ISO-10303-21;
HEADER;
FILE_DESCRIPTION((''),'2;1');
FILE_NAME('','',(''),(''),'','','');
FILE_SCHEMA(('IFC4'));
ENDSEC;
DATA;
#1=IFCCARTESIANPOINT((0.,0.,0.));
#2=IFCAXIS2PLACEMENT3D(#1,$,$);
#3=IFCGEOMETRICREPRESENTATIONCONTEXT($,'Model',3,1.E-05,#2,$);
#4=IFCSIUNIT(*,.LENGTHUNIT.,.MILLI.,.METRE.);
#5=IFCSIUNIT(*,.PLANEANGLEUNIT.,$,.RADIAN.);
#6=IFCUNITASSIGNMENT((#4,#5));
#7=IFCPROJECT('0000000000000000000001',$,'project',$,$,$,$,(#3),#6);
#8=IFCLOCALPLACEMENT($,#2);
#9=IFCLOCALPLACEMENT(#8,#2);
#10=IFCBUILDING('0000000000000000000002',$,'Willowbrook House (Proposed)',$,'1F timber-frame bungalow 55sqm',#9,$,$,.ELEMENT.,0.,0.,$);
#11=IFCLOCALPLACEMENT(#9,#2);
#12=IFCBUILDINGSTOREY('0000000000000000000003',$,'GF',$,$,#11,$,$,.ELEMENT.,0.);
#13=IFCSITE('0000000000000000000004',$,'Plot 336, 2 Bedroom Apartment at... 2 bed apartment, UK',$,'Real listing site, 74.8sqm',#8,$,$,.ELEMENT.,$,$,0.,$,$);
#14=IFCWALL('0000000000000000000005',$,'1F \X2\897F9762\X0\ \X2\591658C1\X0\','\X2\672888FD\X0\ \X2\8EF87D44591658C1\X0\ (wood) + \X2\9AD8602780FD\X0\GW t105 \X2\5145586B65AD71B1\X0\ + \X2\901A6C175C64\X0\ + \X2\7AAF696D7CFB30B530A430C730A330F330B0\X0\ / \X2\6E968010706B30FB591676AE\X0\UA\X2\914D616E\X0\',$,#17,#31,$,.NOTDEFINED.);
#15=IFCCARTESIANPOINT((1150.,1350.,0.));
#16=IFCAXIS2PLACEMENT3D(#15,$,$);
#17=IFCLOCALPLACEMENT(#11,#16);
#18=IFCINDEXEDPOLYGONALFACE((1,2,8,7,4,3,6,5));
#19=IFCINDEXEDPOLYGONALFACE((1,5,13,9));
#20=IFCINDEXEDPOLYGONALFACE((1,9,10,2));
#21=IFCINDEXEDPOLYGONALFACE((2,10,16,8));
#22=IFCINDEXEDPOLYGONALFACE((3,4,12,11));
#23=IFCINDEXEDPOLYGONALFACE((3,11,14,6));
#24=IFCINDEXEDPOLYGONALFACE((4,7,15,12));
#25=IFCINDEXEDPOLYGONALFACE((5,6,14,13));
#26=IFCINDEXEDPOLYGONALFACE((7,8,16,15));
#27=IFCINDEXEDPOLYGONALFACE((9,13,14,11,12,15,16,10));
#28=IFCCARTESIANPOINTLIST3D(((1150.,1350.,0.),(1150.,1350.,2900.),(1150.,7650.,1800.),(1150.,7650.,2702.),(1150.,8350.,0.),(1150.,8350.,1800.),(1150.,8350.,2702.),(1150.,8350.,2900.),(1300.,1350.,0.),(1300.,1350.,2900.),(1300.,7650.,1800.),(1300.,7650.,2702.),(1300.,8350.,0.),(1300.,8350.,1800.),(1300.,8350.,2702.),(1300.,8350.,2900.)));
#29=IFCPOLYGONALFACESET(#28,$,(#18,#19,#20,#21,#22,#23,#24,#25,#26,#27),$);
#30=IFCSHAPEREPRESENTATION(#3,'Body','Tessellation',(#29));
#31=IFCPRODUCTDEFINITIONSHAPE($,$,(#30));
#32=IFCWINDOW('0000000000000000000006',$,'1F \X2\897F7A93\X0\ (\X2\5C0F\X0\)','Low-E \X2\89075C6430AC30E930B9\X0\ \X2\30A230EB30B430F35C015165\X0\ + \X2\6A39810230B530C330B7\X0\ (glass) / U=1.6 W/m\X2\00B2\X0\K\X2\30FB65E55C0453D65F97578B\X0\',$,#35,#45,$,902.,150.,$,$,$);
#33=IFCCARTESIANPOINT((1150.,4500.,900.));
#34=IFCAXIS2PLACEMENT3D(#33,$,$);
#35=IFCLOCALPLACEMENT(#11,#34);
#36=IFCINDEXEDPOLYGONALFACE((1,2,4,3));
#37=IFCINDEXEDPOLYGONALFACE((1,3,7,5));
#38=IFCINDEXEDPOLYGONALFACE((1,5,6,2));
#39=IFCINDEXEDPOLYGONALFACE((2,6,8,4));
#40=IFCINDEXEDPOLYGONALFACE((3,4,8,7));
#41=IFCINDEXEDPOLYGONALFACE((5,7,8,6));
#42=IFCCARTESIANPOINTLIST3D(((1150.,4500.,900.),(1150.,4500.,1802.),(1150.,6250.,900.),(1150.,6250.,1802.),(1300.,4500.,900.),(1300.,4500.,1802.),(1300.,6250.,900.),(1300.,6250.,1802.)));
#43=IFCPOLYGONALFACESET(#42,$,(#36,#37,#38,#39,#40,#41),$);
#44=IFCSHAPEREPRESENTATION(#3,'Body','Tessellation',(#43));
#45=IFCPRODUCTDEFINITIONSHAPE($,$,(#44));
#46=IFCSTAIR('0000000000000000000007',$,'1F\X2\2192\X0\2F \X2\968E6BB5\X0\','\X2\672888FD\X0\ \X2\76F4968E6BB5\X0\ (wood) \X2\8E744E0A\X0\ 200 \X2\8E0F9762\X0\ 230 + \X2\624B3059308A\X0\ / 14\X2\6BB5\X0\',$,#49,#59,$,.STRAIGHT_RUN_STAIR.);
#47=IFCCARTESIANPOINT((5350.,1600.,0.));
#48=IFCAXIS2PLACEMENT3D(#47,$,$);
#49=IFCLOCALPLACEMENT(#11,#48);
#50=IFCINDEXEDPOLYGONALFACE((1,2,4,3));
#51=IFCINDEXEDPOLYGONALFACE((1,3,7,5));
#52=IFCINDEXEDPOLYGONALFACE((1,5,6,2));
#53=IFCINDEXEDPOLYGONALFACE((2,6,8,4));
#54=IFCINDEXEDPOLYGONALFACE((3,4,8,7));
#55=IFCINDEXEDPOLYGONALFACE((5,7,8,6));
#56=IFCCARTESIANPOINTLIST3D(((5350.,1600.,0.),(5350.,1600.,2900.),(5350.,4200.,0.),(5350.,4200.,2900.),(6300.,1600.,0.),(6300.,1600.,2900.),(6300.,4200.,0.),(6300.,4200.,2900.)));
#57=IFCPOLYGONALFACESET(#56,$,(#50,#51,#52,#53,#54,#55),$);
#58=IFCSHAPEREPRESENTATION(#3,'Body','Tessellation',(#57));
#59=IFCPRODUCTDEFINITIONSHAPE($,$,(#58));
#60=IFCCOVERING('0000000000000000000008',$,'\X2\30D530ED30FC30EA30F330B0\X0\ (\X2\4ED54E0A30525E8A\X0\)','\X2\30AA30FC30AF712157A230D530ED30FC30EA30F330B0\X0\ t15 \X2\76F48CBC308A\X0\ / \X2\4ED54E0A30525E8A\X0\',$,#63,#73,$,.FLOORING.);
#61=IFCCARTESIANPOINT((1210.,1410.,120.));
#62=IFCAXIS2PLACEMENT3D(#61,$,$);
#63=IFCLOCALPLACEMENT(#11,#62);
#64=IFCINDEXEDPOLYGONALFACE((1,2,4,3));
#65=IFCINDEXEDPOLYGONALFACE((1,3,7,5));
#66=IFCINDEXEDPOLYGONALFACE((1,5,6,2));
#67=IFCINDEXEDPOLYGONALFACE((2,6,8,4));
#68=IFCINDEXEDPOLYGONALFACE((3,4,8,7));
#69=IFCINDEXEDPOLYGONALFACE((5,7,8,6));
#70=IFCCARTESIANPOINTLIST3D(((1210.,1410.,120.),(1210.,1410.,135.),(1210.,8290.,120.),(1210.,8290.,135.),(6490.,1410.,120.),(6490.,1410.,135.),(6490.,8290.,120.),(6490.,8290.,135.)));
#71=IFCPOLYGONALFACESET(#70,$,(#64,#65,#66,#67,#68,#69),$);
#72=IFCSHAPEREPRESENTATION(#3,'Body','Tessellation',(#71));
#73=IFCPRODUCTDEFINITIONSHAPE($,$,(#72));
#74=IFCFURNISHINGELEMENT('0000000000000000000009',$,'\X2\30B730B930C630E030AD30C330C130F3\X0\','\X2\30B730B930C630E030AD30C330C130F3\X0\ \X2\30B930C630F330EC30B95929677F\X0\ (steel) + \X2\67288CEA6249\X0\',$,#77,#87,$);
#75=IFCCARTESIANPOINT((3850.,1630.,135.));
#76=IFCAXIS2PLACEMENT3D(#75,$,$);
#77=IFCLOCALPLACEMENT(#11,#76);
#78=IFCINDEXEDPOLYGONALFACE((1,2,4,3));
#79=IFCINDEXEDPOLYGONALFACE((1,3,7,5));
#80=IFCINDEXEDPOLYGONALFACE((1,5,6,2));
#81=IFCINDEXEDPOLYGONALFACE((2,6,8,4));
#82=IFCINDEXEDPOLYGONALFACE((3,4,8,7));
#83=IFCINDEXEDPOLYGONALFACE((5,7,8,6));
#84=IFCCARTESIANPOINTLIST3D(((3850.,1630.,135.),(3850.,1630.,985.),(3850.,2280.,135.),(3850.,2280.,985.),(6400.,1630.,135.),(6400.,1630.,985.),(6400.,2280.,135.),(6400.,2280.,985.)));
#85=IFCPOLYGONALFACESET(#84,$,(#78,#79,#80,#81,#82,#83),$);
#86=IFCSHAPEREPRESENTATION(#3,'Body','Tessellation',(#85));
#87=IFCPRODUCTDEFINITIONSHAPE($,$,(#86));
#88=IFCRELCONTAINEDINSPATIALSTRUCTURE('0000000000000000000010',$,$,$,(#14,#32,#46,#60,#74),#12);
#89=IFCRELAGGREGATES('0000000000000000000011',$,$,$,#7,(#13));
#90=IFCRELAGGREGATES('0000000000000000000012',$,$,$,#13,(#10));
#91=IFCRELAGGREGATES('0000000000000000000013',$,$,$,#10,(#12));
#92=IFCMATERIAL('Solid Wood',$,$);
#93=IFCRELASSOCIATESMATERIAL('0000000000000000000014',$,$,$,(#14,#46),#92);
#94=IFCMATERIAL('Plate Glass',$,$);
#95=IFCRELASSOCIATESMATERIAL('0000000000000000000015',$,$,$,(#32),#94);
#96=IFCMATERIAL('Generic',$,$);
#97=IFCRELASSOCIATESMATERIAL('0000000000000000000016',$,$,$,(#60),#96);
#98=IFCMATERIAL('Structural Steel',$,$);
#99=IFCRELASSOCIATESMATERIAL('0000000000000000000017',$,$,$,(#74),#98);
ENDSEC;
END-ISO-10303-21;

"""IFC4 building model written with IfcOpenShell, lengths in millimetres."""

from ifc_helpers import new_model, si_unit, frame, frame_2d, origin, place, context, project, spatial, rectangle, extrude, material, element, fill, save


model = new_model("IFC4")

# Units and contexts
model_context = context("Model", 3, precision=1e-05, world=origin())
ifc_project = project(units=[si_unit("LENGTHUNIT", "METRE", prefix="MILLI"), si_unit("PLANEANGLEUNIT", "RADIAN")], contexts=[model_context])

# Site, building, storey
site_placement = place(None, origin())
site = spatial("IfcSite", under=ifc_project, at=site_placement, Name="Plot 336, 2 Bedroom Apartment at... 2 bed apartment, UK", ObjectType="Real listing site, 74.8sqm", CompositionType="ELEMENT", RefElevation=0.0)
building_placement = place(site_placement, origin())
building = spatial("IfcBuilding", under=site, at=building_placement, Name="Willowbrook House (Proposed)", ObjectType="1F timber-frame bungalow 55sqm", CompositionType="ELEMENT", ElevationOfRefHeight=0.0, ElevationOfTerrain=0.0)
storey_placement = place(building_placement, origin())
storey = spatial("IfcBuildingStorey", under=building, at=storey_placement, Name="GF", CompositionType="ELEMENT", Elevation=0.0)

# Shared definitions
ifc_material_1 = material(Name="Solid Wood")
ifc_material_2 = material(Name="Generic")

# Shared definitions
ifc_material_3 = material(Name="Plate Glass")

# Wall, opening, window
wall_1_placement = place(storey_placement, frame((1150.0, 1350.0, 0.0)))
wall_1 = element("IfcWall", 1, at=wall_1_placement, inside=storey, material=ifc_material_1, Name="1F 西面 外壁", Description="木製 軸組外壁 (wood) + 高性能GW t105 充填断熱 + 通気層 + 窯業系サイディング / 準耐火・外皮UA配慮", PredefinedType="NOTDEFINED", context=model_context, shape_type="SweptSolid", body=[
    extrude(rectangle(XDim=150.0, YDim=7000.0, at=frame_2d((75.0, 3500.0))), frame((1150.0, 1350.0, 0.0)), (0.0, 0.0, 1.0), 2900.0),
])
opening_1_placement = place(storey_placement, frame((1150.0, 4500.0, 900.0)))
opening_1 = element("IfcOpeningElement", 2, at=opening_1_placement, cuts=wall_1, PredefinedType="NOTDEFINED", context=model_context, shape_type="SweptSolid", body=[
    extrude(rectangle(XDim=150.0, YDim=1750.0, at=frame_2d((75.0, 875.0))), frame((1150.0, 4500.0, 900.0)), (0.0, 0.0, 1.0), 902.0),
])
window_1_placement = place(storey_placement, frame((1150.0, 4500.0, 900.0)))
window_1 = element("IfcWindow", 3, at=window_1_placement, inside=storey, material=ifc_material_3, Name="1F 西窓 (小)", Description="Low-E 複層ガラス アルゴン封入 + 樹脂サッシ (glass) / U=1.6 W/m²K・日射取得型", OverallHeight=902.0, OverallWidth=150.0, context=model_context, shape_type="SweptSolid", body=[
    extrude(rectangle(XDim=150.0, YDim=1750.0, at=frame_2d((75.0, 875.0))), frame((1150.0, 4500.0, 900.0)), (0.0, 0.0, 1.0), 902.0),
])
fill(opening_1, window_1)

# Stair
stair_placement = place(storey_placement, frame((5350.0, 1600.0, 0.0)))
element("IfcStair", 4, at=stair_placement, inside=storey, material=ifc_material_1, Name="1F→2F 階段", Description="木製 直階段 (wood) 蹴上 200 踏面 230 + 手すり / 14段", PredefinedType="STRAIGHT_RUN_STAIR", context=model_context, shape_type="SweptSolid", body=[
    extrude(rectangle(XDim=950.0, YDim=2600.0, at=frame_2d((475.0, 1300.0))), frame((5350.0, 1600.0, 0.0)), (0.0, 0.0, 1.0), 2900.0),
])

# Covering
covering_placement = place(storey_placement, frame((1210.0, 1410.0, 120.0)))
element("IfcCovering", 5, at=covering_placement, inside=storey, material=ifc_material_2, Name="フローリング (仕上げ床)", Description="オーク無垢フローリング t15 直貼り / 仕上げ床", PredefinedType="FLOORING", context=model_context, shape_type="SweptSolid", body=[
    extrude(rectangle(XDim=5280.0, YDim=6880.0, at=frame_2d((2640.0, 3440.0))), frame((1210.0, 1410.0, 120.0)), (0.0, 0.0, 1.0), 15.0),
])

# Furnishing element
ifc_material_4 = material(Name="Structural Steel")
furnishing_placement = place(storey_placement, frame((3850.0, 1630.0, 135.0)))
element("IfcFurnishingElement", 6, at=furnishing_placement, inside=storey, material=ifc_material_4, Name="システムキッチン", Description="システムキッチン ステンレス天板 (steel) + 木質扉", context=model_context, shape_type="SweptSolid", body=[
    extrude(rectangle(XDim=2550.0, YDim=650.0, at=frame_2d((1275.0, 325.0))), frame((3850.0, 1630.0, 135.0)), (0.0, 0.0, 1.0), 850.0),
])

save(model, "model.ifc")
